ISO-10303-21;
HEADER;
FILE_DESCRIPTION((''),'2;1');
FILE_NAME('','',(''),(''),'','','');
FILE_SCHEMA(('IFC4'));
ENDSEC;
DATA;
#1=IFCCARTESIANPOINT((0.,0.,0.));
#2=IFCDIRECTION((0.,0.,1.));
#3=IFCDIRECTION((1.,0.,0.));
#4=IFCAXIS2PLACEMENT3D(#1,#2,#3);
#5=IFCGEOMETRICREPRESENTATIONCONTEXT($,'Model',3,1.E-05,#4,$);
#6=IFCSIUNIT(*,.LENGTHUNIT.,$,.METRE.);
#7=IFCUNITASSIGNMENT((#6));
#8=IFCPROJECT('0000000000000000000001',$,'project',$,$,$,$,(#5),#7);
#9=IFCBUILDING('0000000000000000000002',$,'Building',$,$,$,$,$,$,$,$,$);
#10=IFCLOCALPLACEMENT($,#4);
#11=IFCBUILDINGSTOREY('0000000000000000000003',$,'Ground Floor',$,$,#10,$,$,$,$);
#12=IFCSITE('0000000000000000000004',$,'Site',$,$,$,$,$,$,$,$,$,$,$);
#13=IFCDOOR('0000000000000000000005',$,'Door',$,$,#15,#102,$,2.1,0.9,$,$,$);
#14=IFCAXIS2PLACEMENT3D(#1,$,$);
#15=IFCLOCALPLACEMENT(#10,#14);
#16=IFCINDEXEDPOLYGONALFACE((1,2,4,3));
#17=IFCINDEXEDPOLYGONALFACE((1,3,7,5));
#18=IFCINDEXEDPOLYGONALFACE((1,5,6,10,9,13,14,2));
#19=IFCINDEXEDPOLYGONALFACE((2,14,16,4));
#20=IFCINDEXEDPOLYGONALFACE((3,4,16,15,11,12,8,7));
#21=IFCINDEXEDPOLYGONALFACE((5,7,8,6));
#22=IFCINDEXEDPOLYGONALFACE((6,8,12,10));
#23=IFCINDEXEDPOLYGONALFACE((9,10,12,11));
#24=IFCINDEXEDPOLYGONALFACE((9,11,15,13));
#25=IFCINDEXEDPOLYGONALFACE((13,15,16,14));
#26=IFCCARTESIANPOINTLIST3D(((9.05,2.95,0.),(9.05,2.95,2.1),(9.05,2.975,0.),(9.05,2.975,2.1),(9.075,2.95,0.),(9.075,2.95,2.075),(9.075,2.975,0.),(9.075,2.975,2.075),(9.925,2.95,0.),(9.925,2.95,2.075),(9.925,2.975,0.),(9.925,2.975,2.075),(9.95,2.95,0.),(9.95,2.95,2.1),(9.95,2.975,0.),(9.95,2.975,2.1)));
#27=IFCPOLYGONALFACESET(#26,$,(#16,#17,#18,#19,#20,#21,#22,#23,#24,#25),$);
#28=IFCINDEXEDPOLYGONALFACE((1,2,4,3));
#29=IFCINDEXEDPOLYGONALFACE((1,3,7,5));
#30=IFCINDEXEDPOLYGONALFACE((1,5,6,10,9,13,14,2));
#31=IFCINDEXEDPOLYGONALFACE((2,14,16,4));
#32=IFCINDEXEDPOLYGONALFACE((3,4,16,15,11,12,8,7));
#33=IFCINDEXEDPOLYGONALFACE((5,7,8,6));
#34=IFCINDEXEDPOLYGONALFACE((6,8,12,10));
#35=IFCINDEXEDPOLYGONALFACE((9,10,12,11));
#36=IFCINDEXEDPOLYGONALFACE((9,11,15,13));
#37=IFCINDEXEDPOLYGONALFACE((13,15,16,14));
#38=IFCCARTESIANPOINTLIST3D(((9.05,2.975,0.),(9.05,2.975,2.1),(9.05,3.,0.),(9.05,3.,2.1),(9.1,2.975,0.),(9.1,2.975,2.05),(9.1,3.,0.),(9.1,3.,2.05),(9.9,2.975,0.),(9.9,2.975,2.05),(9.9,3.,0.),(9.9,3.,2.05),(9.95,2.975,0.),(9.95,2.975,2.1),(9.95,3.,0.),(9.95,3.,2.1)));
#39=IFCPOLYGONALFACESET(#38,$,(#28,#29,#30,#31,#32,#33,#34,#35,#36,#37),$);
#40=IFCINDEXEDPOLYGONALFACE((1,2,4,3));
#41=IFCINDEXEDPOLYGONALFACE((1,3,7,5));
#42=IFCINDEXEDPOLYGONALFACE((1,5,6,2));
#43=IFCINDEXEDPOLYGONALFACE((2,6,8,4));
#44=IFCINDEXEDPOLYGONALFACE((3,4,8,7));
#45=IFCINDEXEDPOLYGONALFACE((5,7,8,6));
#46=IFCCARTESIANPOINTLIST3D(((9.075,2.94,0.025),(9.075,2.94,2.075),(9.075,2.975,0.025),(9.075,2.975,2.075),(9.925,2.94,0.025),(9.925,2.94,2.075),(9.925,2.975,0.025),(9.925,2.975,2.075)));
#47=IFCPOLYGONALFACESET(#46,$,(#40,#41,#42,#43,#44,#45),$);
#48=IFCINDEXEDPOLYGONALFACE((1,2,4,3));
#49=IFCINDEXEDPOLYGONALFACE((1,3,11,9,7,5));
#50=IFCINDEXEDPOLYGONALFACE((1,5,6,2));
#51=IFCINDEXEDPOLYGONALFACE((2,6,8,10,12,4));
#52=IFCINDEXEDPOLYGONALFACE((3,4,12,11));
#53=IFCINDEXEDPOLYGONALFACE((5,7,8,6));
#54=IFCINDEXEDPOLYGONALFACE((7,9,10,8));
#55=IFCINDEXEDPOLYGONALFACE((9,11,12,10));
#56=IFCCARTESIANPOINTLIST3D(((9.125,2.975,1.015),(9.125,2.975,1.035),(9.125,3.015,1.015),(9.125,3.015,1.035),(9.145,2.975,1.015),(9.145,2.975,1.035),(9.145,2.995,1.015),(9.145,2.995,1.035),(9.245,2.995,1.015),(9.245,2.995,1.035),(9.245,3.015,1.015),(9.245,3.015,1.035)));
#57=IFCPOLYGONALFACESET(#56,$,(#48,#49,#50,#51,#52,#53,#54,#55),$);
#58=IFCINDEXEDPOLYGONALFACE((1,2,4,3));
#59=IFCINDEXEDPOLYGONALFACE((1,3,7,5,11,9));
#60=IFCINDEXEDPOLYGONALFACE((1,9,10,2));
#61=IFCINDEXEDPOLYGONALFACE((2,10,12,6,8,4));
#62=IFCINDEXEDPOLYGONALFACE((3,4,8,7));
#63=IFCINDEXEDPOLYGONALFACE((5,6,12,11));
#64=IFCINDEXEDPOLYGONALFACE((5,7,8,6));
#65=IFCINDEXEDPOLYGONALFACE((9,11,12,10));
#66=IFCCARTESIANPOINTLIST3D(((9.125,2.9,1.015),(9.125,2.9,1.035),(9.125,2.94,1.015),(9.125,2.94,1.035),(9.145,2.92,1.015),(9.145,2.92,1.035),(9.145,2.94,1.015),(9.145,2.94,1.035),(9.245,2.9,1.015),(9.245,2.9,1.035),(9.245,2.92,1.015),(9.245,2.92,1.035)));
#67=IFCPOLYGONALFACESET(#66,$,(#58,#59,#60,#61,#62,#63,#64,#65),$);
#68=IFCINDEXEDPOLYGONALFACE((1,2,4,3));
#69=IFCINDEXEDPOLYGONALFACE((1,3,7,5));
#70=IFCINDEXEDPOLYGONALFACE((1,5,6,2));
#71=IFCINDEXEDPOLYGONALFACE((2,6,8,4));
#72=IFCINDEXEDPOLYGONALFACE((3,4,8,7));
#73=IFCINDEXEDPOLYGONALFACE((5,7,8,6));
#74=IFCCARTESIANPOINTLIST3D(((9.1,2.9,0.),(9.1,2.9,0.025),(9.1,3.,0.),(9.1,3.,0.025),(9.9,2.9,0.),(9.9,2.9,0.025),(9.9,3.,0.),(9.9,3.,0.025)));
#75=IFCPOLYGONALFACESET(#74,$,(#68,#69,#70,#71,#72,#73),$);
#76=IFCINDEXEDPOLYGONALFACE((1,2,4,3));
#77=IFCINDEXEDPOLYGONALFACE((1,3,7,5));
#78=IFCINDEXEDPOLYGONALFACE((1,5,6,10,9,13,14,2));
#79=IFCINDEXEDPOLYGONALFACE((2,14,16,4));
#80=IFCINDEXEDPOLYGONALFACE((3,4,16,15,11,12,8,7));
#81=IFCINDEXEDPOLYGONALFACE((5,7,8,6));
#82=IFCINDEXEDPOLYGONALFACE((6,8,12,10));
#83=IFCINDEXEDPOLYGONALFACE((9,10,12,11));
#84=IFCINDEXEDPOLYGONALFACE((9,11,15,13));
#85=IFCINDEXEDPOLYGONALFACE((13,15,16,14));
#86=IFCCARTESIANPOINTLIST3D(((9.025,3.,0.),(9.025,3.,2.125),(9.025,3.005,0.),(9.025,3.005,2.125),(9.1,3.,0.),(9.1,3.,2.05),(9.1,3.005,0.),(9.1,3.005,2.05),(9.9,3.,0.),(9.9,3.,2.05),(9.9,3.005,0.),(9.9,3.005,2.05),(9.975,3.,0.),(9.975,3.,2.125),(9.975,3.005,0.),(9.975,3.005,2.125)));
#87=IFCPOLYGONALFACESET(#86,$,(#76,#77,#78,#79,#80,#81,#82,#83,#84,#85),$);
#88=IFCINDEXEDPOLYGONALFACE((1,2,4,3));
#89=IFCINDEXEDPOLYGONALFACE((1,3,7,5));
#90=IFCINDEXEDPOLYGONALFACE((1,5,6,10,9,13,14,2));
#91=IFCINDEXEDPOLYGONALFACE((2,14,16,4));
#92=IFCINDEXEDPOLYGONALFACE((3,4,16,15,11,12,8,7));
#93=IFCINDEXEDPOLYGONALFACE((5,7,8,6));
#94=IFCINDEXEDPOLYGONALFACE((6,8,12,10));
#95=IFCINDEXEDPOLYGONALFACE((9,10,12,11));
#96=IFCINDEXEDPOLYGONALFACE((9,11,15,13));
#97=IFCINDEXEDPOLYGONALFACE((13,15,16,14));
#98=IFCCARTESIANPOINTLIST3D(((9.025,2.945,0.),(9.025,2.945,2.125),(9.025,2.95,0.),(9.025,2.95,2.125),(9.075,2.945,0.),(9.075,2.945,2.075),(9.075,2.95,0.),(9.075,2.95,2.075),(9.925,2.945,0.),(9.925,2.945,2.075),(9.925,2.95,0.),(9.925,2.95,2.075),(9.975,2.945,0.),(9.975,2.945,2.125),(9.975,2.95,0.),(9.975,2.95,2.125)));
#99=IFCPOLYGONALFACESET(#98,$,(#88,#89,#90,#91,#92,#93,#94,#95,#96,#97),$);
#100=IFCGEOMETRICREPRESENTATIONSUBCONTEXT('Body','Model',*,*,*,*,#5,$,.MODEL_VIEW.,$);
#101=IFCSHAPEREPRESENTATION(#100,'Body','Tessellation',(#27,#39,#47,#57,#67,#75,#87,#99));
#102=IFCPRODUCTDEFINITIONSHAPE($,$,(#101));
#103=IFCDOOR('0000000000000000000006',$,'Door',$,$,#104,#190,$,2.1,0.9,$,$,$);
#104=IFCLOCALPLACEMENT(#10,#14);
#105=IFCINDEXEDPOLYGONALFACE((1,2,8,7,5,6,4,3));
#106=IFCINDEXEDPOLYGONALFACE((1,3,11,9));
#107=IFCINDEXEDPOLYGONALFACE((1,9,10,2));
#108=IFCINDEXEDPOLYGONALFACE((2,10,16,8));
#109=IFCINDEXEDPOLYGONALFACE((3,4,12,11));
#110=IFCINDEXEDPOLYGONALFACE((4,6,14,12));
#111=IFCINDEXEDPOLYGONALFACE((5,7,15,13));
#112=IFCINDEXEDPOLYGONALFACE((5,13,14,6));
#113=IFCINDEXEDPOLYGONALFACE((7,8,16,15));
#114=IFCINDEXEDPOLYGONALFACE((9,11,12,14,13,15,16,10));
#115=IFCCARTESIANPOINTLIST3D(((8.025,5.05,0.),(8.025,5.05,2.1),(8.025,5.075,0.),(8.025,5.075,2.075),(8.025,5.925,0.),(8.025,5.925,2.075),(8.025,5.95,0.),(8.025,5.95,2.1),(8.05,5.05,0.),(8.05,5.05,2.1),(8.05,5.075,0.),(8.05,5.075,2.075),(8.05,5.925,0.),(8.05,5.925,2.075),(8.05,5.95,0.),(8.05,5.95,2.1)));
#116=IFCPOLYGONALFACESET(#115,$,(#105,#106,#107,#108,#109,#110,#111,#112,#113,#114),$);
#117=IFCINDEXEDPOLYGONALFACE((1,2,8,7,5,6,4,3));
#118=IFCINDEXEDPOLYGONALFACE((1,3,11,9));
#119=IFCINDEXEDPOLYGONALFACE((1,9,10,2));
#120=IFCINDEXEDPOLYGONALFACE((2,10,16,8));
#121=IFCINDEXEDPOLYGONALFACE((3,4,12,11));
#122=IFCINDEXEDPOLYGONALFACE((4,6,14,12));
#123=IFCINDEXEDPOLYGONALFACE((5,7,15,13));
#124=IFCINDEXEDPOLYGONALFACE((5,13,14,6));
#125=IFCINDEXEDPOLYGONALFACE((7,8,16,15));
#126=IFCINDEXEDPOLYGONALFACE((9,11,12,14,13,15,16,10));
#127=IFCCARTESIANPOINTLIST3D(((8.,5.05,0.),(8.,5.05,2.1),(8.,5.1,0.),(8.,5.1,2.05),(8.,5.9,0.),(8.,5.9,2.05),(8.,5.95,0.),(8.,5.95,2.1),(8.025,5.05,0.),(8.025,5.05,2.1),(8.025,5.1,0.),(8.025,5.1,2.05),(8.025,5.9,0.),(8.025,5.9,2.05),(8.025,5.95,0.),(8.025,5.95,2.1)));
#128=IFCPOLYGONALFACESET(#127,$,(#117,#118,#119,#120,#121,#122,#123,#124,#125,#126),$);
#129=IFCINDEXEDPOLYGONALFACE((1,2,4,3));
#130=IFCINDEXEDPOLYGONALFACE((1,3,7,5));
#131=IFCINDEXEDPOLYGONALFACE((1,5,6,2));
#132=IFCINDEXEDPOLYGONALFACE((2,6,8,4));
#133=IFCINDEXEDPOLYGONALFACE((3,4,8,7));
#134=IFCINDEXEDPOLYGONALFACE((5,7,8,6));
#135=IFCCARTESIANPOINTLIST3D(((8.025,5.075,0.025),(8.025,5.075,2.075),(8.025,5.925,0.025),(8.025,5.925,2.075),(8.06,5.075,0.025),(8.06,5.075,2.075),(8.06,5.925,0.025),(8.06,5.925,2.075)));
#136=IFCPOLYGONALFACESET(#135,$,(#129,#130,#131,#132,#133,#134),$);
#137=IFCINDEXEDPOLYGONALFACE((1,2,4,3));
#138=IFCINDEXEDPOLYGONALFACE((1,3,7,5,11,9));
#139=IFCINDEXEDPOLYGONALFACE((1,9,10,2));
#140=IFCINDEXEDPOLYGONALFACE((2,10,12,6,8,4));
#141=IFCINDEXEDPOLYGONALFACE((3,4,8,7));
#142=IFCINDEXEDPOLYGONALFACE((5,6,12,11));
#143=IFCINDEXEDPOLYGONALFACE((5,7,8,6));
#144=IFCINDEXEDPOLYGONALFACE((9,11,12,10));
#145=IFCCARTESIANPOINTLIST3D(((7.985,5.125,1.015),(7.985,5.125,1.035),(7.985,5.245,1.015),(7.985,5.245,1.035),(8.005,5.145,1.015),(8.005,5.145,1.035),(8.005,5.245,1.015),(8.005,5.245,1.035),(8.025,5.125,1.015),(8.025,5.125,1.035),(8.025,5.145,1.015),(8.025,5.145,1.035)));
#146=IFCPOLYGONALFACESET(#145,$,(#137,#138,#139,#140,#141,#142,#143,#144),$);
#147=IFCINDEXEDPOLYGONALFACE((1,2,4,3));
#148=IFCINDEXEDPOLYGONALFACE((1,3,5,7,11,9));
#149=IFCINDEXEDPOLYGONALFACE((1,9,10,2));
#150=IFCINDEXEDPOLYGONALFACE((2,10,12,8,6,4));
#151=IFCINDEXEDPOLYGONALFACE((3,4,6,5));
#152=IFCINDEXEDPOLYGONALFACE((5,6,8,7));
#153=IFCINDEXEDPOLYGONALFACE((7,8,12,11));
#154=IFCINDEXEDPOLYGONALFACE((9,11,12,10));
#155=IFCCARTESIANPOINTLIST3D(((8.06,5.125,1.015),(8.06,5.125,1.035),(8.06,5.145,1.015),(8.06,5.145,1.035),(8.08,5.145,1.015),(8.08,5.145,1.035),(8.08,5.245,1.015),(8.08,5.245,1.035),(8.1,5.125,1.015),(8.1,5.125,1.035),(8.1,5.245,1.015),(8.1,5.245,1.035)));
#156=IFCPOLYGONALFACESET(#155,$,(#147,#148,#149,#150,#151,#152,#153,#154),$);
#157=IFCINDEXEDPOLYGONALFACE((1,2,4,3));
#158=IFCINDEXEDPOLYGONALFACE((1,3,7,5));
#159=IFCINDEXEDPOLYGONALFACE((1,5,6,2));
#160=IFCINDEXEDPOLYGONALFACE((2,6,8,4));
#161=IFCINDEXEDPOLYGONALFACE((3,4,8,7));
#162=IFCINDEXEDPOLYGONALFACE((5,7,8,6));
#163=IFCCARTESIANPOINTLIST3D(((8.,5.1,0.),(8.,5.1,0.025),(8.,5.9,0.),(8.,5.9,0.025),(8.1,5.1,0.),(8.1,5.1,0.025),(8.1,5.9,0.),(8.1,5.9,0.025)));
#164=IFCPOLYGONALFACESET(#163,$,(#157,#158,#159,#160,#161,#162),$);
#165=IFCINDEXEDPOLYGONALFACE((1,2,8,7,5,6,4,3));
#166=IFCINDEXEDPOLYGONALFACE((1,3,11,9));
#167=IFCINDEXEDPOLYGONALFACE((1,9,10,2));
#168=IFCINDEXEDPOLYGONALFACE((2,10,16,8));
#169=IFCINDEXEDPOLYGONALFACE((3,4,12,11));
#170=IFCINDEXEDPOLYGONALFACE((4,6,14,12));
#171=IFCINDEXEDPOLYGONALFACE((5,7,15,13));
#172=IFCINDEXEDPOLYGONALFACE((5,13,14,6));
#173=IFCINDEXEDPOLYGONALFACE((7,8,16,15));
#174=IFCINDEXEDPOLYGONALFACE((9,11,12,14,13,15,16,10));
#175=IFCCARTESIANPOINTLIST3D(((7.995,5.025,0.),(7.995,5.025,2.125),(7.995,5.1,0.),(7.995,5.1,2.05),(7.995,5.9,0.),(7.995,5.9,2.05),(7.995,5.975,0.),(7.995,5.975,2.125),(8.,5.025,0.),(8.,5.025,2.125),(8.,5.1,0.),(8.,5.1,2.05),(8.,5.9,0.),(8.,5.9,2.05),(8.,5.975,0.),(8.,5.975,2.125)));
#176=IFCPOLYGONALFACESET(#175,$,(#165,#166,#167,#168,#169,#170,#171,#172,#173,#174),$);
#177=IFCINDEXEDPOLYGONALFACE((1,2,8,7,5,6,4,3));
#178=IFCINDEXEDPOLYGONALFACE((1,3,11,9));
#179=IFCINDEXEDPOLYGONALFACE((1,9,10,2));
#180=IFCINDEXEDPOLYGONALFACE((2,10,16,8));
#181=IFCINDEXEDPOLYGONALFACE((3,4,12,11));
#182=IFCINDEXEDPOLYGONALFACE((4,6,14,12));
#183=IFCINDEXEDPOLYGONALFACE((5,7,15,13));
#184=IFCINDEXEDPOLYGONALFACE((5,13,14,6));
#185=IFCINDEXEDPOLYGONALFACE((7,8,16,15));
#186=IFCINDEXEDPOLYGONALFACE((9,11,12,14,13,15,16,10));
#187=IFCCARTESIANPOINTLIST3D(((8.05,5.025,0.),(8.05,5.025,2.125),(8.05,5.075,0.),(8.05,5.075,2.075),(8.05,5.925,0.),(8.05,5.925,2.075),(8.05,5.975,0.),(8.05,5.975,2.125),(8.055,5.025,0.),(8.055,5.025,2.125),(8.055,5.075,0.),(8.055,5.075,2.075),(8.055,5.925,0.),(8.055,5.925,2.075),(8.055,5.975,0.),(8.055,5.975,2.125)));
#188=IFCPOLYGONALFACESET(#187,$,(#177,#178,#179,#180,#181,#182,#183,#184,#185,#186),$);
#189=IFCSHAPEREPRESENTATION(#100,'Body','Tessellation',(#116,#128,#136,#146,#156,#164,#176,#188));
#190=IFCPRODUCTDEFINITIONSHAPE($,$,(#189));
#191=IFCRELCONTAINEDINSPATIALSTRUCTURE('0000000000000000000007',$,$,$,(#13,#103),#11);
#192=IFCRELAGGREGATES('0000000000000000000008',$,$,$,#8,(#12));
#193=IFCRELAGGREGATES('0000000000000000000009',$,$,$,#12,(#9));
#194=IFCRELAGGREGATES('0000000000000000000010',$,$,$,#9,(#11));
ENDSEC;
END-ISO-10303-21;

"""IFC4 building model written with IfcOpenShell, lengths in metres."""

from ifc_helpers import new_model, si_unit, frame, origin_with_axes, place, context, subcontext, project, spatial, line, indexed_curve, outline, extrude, element, save


model = new_model("IFC4")

# Units and contexts
model_context = context("Model", 3, precision=1e-05, world=origin_with_axes())
body_context = subcontext(model_context, "Body", "Model", "MODEL_VIEW")
ifc_project = project(units=[si_unit("LENGTHUNIT", "METRE")], contexts=[model_context])

# Site, building, storey
site = spatial("IfcSite", under=ifc_project, Name="Site")
building = spatial("IfcBuilding", under=site, Name="Building")
storey_placement = place(None, origin_with_axes())
storey = spatial("IfcBuildingStorey", under=building, at=storey_placement, Name="Ground Floor")

# Doors
door_1_placement = place(storey_placement, frame((9.95, 3.0, 0.0), z_axis=(0.0, 0.0, 1.0), x_axis=(-1.0, 0.0, 0.0)))
element("IfcDoor", 1, at=door_1_placement, inside=storey, Name="Door", OverallHeight=2.1, OverallWidth=0.9, context=body_context, shape_type="SweptSolid", body=[
    extrude(outline(indexed_curve([(0.0, 0.0), (0.0, 2.1), (0.9, 2.1), (0.9, 0.0), (0.875, 0.0), (0.875, 2.075), (0.025, 2.075), (0.025, 0.0)], segments=[line(1, 2, 3, 4, 5, 6, 7, 8, 1)])), frame((0.0, 0.025, 0.0), z_axis=(0.0, -1.0, 0.0), x_axis=(1.0, 0.0, 0.0)), (0.0, 0.0, -1.0), 0.025),
    extrude(outline(indexed_curve([(0.0, 0.0), (0.0, 2.1), (0.9, 2.1), (0.9, 0.0), (0.85, 0.0), (0.85, 2.05), (0.05, 2.05), (0.05, 0.0)], segments=[line(1, 2, 3, 4, 5, 6, 7, 8, 1)])), frame((0.0, 0.0, 0.0), z_axis=(0.0, -1.0, 0.0), x_axis=(1.0, 0.0, 0.0)), (0.0, 0.0, -1.0), 0.025),
    extrude(outline(indexed_curve([(0.0, 0.0), (0.85, 0.0), (0.85, 0.035), (0.0, 0.035)], segments=[line(1, 2, 3, 4, 1)])), frame((0.025, 0.025, 0.025), z_axis=(0.0, 0.0, 1.0), x_axis=(1.0, 0.0, 0.0)), (0.0, 0.0, 1.0), 2.05),
    extrude(outline(indexed_curve([(0.0, 0.0), (0.0, -0.04), (-0.12, -0.04), (-0.12, -0.02), (-0.02, -0.02), (-0.02, 0.0)], segments=[line(1, 2, 3, 4, 5, 6, 1)])), frame((0.825, 0.025, 1.015), z_axis=(0.0, 0.0, 1.0), x_axis=(1.0, 0.0, 0.0)), (0.0, 0.0, 1.0), 0.02),
    extrude(outline(indexed_curve([(0.0, 0.0), (0.0, 0.04), (-0.12, 0.04), (-0.12, 0.02), (-0.02, 0.02), (-0.02, 0.0)], segments=[line(1, 2, 3, 4, 5, 6, 1)])), frame((0.825, 0.06, 1.015), z_axis=(0.0, 0.0, 1.0), x_axis=(1.0, 0.0, 0.0)), (0.0, 0.0, 1.0), 0.02),
    extrude(outline(indexed_curve([(0.0, 0.0), (0.8, 0.0), (0.8, 0.1), (0.0, 0.1)], segments=[line(1, 2, 3, 4, 1)])), frame((0.05, 0.0, 0.0), z_axis=(0.0, 0.0, 1.0), x_axis=(1.0, 0.0, 0.0)), (0.0, 0.0, 1.0), 0.025),
    extrude(outline(indexed_curve([(0.0, 0.0), (0.0, 2.125), (0.95, 2.125), (0.95, 0.0), (0.875, 0.0), (0.875, 2.05), (0.075, 2.05), (0.075, 0.0)], segments=[line(1, 2, 3, 4, 5, 6, 7, 8, 1)])), frame((-0.025, -0.005, 0.0), z_axis=(0.0, -1.0, 0.0), x_axis=(1.0, 0.0, 0.0)), (0.0, 0.0, -1.0), 0.005),
    extrude(outline(indexed_curve([(0.0, 0.0), (0.0, 2.125), (0.95, 2.125), (0.95, 0.0), (0.9, 0.0), (0.9, 2.075), (0.05, 2.075), (0.05, 0.0)], segments=[line(1, 2, 3, 4, 5, 6, 7, 8, 1)])), frame((-0.025, 0.05, 0.0), z_axis=(0.0, -1.0, 0.0), x_axis=(1.0, 0.0, 0.0)), (0.0, 0.0, -1.0), 0.005),
])
door_2_placement = place(storey_placement, frame((8.0, 5.95, 0.0), z_axis=(0.0, 0.0, 1.0), x_axis=(0.0, -1.0, 0.0)))
element("IfcDoor", 2, at=door_2_placement, inside=storey, Name="Door", OverallHeight=2.1, OverallWidth=0.9, context=body_context, shape_type="SweptSolid", body=[
    extrude(outline(indexed_curve([(0.0, 0.0), (0.0, 2.1), (0.9, 2.1), (0.9, 0.0), (0.875, 0.0), (0.875, 2.075), (0.025, 2.075), (0.025, 0.0)], segments=[line(1, 2, 3, 4, 5, 6, 7, 8, 1)])), frame((0.0, 0.025, 0.0), z_axis=(0.0, -1.0, 0.0), x_axis=(1.0, 0.0, 0.0)), (0.0, 0.0, -1.0), 0.025),
    extrude(outline(indexed_curve([(0.0, 0.0), (0.0, 2.1), (0.9, 2.1), (0.9, 0.0), (0.85, 0.0), (0.85, 2.05), (0.05, 2.05), (0.05, 0.0)], segments=[line(1, 2, 3, 4, 5, 6, 7, 8, 1)])), frame((0.0, 0.0, 0.0), z_axis=(0.0, -1.0, 0.0), x_axis=(1.0, 0.0, 0.0)), (0.0, 0.0, -1.0), 0.025),
    extrude(outline(indexed_curve([(0.0, 0.0), (0.85, 0.0), (0.85, 0.035), (0.0, 0.035)], segments=[line(1, 2, 3, 4, 1)])), frame((0.025, 0.025, 0.025), z_axis=(0.0, 0.0, 1.0), x_axis=(1.0, 0.0, 0.0)), (0.0, 0.0, 1.0), 2.05),
    extrude(outline(indexed_curve([(0.0, 0.0), (0.0, -0.04), (-0.12, -0.04), (-0.12, -0.02), (-0.02, -0.02), (-0.02, 0.0)], segments=[line(1, 2, 3, 4, 5, 6, 1)])), frame((0.825, 0.025, 1.015), z_axis=(0.0, 0.0, 1.0), x_axis=(1.0, 0.0, 0.0)), (0.0, 0.0, 1.0), 0.02),
    extrude(outline(indexed_curve([(0.0, 0.0), (0.0, 0.04), (-0.12, 0.04), (-0.12, 0.02), (-0.02, 0.02), (-0.02, 0.0)], segments=[line(1, 2, 3, 4, 5, 6, 1)])), frame((0.825, 0.06, 1.015), z_axis=(0.0, 0.0, 1.0), x_axis=(1.0, 0.0, 0.0)), (0.0, 0.0, 1.0), 0.02),
    extrude(outline(indexed_curve([(0.0, 0.0), (0.8, 0.0), (0.8, 0.1), (0.0, 0.1)], segments=[line(1, 2, 3, 4, 1)])), frame((0.05, 0.0, 0.0), z_axis=(0.0, 0.0, 1.0), x_axis=(1.0, 0.0, 0.0)), (0.0, 0.0, 1.0), 0.025),
    extrude(outline(indexed_curve([(0.0, 0.0), (0.0, 2.125), (0.95, 2.125), (0.95, 0.0), (0.875, 0.0), (0.875, 2.05), (0.075, 2.05), (0.075, 0.0)], segments=[line(1, 2, 3, 4, 5, 6, 7, 8, 1)])), frame((-0.025, -0.005, 0.0), z_axis=(0.0, -1.0, 0.0), x_axis=(1.0, 0.0, 0.0)), (0.0, 0.0, -1.0), 0.005),
    extrude(outline(indexed_curve([(0.0, 0.0), (0.0, 2.125), (0.95, 2.125), (0.95, 0.0), (0.9, 0.0), (0.9, 2.075), (0.05, 2.075), (0.05, 0.0)], segments=[line(1, 2, 3, 4, 5, 6, 7, 8, 1)])), frame((-0.025, 0.05, 0.0), z_axis=(0.0, -1.0, 0.0), x_axis=(1.0, 0.0, 0.0)), (0.0, 0.0, -1.0), 0.005),
])

save(model, "model.ifc")
